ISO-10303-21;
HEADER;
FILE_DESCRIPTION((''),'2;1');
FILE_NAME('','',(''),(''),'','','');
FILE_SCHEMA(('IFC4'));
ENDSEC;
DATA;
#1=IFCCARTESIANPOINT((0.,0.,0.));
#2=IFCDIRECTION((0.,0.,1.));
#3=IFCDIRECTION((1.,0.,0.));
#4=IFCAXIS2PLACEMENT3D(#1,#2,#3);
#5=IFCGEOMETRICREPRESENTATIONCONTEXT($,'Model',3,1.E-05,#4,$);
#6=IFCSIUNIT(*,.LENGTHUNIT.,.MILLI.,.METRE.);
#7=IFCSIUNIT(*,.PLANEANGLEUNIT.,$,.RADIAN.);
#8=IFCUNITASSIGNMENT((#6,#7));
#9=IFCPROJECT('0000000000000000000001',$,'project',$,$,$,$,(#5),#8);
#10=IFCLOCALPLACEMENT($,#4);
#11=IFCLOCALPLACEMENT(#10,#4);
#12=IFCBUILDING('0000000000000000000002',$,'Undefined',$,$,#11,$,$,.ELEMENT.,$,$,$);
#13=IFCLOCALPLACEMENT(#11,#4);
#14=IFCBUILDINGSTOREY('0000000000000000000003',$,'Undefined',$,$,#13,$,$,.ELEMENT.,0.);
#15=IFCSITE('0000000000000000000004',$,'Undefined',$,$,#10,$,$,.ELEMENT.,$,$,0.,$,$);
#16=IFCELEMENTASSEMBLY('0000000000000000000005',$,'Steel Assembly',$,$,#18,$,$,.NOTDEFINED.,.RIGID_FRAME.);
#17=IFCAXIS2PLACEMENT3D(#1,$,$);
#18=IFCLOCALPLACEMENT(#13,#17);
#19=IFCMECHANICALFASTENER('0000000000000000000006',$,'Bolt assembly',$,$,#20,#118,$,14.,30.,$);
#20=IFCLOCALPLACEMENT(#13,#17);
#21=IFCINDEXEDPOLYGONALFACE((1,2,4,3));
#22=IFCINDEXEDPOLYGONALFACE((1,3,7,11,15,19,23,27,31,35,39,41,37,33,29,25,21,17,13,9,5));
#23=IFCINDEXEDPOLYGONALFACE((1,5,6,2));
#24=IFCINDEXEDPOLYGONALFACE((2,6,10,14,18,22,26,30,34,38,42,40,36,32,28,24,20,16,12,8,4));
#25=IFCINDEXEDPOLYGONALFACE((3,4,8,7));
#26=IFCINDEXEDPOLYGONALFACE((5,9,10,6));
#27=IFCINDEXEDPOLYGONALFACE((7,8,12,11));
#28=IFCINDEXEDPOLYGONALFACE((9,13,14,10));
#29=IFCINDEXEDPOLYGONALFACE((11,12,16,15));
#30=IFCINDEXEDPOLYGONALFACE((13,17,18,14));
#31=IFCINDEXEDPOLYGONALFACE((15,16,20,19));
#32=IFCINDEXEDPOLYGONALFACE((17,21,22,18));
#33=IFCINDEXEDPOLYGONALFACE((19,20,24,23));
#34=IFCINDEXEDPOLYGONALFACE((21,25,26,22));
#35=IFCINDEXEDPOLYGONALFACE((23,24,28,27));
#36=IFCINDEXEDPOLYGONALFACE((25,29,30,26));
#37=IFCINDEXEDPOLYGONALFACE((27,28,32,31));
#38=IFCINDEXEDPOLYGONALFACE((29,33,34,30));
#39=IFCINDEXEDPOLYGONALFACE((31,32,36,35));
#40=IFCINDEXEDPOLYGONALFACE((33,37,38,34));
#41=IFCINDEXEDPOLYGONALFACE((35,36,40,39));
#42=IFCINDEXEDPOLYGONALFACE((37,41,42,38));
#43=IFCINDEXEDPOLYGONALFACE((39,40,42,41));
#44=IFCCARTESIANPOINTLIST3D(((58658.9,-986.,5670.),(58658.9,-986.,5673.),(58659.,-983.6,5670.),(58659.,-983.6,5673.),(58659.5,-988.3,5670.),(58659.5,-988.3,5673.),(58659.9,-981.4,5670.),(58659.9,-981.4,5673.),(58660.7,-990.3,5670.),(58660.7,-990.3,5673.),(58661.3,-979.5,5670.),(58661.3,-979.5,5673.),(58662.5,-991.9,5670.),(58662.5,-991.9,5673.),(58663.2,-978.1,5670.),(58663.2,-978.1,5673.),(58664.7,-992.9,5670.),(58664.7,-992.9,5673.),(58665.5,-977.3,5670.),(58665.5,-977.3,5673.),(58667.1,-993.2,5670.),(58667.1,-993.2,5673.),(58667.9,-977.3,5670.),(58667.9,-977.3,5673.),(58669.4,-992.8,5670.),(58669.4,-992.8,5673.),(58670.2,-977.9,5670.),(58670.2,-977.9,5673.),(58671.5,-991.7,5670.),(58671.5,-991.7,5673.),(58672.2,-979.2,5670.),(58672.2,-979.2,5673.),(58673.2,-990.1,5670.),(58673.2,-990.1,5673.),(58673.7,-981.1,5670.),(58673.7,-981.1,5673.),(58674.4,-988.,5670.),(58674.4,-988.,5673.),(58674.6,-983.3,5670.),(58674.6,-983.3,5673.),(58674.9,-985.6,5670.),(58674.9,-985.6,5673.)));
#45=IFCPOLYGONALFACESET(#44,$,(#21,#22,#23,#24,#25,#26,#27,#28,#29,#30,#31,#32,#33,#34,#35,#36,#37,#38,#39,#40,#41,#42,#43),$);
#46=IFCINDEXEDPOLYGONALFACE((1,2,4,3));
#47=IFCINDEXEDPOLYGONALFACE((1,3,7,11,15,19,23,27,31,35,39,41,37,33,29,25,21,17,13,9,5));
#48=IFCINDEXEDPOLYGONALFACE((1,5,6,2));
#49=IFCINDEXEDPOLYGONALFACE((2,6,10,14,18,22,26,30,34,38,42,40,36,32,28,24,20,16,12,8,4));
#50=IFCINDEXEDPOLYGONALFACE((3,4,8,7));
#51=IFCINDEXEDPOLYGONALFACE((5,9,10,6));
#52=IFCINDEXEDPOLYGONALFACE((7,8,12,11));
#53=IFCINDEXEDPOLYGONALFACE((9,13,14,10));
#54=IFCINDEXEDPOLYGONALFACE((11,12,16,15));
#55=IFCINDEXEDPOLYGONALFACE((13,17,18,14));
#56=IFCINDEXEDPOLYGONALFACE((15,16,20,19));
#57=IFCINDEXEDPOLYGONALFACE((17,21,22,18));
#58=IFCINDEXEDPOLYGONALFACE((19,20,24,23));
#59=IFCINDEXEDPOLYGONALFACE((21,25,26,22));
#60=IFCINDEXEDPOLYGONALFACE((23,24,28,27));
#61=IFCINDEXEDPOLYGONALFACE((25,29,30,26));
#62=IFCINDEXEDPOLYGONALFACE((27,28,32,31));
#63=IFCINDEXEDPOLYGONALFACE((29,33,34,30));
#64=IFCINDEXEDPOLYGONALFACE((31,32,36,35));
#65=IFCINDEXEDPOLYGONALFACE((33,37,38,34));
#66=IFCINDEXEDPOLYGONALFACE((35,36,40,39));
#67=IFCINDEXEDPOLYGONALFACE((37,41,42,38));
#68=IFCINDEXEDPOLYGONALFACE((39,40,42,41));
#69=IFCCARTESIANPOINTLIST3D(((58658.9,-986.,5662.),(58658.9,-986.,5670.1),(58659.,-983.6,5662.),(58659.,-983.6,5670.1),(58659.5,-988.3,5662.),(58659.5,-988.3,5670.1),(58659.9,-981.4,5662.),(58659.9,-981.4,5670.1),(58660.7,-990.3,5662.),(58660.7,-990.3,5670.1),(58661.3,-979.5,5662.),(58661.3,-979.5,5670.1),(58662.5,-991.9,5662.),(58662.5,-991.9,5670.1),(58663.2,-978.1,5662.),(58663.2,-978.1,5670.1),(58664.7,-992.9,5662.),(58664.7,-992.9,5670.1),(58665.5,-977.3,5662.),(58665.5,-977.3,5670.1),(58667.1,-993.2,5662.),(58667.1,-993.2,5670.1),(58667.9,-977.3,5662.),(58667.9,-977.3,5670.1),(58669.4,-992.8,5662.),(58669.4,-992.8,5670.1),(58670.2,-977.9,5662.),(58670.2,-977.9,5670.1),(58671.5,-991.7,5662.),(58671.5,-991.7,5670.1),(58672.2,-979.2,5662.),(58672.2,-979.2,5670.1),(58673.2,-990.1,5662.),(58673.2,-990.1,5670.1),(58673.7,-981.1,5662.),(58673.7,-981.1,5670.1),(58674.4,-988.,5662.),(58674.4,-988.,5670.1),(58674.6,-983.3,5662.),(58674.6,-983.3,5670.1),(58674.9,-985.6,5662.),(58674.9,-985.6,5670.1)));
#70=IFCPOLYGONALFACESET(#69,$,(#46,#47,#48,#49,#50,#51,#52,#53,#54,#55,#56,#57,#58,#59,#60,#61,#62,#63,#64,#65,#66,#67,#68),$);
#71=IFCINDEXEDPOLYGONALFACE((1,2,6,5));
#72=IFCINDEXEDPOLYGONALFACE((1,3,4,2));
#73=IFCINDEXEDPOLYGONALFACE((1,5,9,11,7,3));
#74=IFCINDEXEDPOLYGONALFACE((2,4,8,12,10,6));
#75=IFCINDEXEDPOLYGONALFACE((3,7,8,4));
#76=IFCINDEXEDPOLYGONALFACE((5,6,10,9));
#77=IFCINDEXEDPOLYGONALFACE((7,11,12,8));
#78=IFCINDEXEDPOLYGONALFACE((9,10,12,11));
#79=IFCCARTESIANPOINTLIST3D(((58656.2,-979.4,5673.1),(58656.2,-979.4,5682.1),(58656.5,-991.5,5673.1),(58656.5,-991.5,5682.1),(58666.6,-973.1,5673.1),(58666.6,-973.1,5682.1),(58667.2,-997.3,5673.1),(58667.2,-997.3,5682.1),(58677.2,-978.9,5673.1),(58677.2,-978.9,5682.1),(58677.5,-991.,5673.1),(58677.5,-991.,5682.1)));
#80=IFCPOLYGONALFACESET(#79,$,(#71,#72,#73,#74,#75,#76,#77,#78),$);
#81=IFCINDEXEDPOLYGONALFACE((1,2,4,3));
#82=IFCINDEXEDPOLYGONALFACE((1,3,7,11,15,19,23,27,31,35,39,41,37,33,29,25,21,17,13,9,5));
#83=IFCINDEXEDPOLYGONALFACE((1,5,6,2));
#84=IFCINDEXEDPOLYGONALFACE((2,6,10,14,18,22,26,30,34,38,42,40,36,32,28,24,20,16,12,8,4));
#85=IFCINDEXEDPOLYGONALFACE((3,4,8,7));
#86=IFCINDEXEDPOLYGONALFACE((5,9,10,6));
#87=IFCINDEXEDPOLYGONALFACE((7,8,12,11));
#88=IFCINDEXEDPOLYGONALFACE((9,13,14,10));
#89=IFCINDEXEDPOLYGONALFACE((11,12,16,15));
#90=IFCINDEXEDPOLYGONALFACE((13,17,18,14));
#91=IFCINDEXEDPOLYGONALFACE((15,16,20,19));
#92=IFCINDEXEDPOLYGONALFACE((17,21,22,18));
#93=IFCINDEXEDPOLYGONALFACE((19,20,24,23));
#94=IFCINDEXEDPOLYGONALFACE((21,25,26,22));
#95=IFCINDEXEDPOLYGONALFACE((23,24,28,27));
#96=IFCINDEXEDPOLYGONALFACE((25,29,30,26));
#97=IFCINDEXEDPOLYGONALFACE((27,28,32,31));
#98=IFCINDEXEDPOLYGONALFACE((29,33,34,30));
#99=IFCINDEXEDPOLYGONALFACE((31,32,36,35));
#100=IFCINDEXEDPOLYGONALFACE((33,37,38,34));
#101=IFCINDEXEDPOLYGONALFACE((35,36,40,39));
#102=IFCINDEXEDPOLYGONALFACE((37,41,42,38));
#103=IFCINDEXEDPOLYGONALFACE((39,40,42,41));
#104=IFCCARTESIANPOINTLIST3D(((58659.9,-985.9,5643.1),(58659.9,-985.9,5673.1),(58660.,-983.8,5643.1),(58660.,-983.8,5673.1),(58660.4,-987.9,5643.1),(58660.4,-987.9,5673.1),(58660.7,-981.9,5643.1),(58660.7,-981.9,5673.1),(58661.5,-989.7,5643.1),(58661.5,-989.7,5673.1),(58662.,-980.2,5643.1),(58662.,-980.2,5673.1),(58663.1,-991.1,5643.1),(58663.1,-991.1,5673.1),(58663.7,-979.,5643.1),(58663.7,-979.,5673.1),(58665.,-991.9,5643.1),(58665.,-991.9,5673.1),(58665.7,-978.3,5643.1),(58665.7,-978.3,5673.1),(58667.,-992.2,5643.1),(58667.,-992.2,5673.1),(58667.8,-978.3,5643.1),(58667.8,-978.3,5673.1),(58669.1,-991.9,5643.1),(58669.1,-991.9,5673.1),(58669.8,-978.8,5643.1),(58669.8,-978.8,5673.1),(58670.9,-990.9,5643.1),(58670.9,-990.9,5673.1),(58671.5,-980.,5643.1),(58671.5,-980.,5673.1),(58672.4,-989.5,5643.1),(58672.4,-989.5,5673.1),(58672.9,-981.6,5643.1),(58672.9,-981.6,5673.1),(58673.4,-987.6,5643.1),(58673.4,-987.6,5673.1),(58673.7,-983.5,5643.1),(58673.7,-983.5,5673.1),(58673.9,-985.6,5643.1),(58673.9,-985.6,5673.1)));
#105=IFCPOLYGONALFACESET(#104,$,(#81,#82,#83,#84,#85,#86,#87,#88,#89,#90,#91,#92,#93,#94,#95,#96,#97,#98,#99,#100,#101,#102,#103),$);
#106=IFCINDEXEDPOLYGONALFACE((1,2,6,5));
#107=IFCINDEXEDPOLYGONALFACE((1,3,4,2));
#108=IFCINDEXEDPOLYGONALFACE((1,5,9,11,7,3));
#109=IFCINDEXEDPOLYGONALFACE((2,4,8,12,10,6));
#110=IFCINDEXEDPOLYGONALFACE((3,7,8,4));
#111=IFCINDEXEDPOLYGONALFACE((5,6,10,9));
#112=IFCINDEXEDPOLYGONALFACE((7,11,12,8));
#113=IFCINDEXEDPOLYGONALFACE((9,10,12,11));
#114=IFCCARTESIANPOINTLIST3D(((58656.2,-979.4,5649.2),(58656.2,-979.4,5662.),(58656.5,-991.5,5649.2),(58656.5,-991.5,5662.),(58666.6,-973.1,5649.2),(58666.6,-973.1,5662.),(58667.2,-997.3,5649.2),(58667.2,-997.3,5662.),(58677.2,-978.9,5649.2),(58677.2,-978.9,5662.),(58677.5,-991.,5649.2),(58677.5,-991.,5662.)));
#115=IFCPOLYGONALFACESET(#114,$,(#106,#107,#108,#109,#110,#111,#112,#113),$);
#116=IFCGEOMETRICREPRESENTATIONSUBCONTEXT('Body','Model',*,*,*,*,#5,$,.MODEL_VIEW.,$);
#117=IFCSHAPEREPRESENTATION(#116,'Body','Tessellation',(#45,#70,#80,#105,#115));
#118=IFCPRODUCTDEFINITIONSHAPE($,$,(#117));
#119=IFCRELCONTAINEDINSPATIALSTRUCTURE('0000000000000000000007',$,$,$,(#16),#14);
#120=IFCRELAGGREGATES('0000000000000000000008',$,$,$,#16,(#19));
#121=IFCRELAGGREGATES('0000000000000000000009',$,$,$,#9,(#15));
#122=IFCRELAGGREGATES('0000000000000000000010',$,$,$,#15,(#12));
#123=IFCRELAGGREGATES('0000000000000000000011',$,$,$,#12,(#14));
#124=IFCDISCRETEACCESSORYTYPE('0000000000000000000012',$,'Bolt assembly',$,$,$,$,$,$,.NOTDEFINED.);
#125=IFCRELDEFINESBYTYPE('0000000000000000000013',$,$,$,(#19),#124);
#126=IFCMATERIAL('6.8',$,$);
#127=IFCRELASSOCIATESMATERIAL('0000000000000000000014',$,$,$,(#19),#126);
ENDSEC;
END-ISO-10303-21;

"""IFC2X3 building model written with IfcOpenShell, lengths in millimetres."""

from ifc_helpers import new_model, si_unit, frame, origin_with_axes, origin_2d_with_axis, place, context, subcontext, project, spatial, polyline, circle, outline, extrude, source, transform, mapped, material, type_object, element, aggregate, save


model = new_model("IFC2X3")

# Units and contexts
model_context = context("Model", 3, precision=1e-05, world=origin_with_axes())
body_context = subcontext(model_context, "Body", "Model", "MODEL_VIEW")
ifc_project = project(units=[si_unit("LENGTHUNIT", "METRE", prefix="MILLI"), si_unit("PLANEANGLEUNIT", "RADIAN")], contexts=[model_context])

# Site, building, storey
site_placement = place(None, origin_with_axes())
site = spatial("IfcSite", under=ifc_project, at=site_placement, Name="Undefined", CompositionType="ELEMENT", RefElevation=0.0)
building_placement = place(site_placement, origin_with_axes())
building = spatial("IfcBuilding", under=site, at=building_placement, Name="Undefined", CompositionType="ELEMENT")
storey_placement = place(building_placement, origin_with_axes())
storey = spatial("IfcBuildingStorey", under=building, at=storey_placement, Name="Undefined", CompositionType="ELEMENT", Elevation=0.0)

# Element assembly
assembly_1_placement = place(storey_placement, origin_with_axes())
assembly_1 = element("IfcElementAssembly", 1, at=assembly_1_placement, inside=storey, Name="Steel Assembly", AssemblyPlace="NOTDEFINED", PredefinedType="RIGID_FRAME")

# Shared definitions
ifc_material_1 = material(Name="6.8")
discrete_accessory_type_1 = type_object("IfcDiscreteAccessoryType", Name="Bolt assembly")

# Mechanical fastener
shared_shape_1 = source(origin_with_axes(), body_context, "Body", "SweptSolid", [
    extrude(circle(Radius=8.0, at=origin_2d_with_axis()), frame((0.0, -3.0, 0.0), z_axis=(0.0, 1.0, 0.0), x_axis=(1.0, 0.0, 0.0)), (0.0, 0.0, 1.0), 3.0),
    extrude(circle(Radius=8.0, at=origin_2d_with_axis()), frame((0.0, -0.1, 0.0), z_axis=(0.0, 1.0, 0.0), x_axis=(1.0, 0.0, 0.0)), (0.0, 0.0, 1.0), 8.1),
    extrude(outline(polyline([(12.1, 0.0), (6.1, 10.5), (-6.1, 10.5), (-12.1, 0.0), (-6.1, -10.5), (6.1, -10.5), (12.1, 0.0)])), frame((0.0, -12.1, 0.0), z_axis=(0.0, 1.0, 0.0), x_axis=(1.0, 0.0, 0.0)), (0.0, 0.0, 1.0), 9.0),
    extrude(circle(Radius=7.0, at=origin_2d_with_axis()), frame((0.0, -3.1, 0.0), z_axis=(0.0, 1.0, 0.0), x_axis=(1.0, 0.0, 0.0)), (0.0, 0.0, 1.0), 30.0),
    extrude(outline(polyline([(12.1, 0.0), (6.1, 10.5), (-6.1, 10.5), (-12.1, 0.0), (-6.1, -10.5), (6.1, -10.5), (12.1, 0.0)])), frame((0.0, 8.0, 0.0), z_axis=(0.0, 1.0, 0.0), x_axis=(1.0, 0.0, 0.0)), (0.0, 0.0, 1.0), 12.8),
])
mechanical_fastener_1_placement = place(assembly_1_placement, frame((58666.9, -985.2, 5670.0), z_axis=(0.999745, 0.022588, 0.0), x_axis=(0.022588, -0.999745, 0.000001)))
mechanical_fastener_1 = element("IfcMechanicalFastener", 2, at=mechanical_fastener_1_placement, type_object=discrete_accessory_type_1, material=ifc_material_1, Name="Bolt assembly", NominalDiameter=14.0, NominalLength=30.0, context=body_context, shape_type="MappedRepresentation", body=[
    mapped(shared_shape_1, transform((0.0, 0.0, 0.0))),
])
aggregate(assembly_1, [mechanical_fastener_1])

save(model, "model.ifc")
